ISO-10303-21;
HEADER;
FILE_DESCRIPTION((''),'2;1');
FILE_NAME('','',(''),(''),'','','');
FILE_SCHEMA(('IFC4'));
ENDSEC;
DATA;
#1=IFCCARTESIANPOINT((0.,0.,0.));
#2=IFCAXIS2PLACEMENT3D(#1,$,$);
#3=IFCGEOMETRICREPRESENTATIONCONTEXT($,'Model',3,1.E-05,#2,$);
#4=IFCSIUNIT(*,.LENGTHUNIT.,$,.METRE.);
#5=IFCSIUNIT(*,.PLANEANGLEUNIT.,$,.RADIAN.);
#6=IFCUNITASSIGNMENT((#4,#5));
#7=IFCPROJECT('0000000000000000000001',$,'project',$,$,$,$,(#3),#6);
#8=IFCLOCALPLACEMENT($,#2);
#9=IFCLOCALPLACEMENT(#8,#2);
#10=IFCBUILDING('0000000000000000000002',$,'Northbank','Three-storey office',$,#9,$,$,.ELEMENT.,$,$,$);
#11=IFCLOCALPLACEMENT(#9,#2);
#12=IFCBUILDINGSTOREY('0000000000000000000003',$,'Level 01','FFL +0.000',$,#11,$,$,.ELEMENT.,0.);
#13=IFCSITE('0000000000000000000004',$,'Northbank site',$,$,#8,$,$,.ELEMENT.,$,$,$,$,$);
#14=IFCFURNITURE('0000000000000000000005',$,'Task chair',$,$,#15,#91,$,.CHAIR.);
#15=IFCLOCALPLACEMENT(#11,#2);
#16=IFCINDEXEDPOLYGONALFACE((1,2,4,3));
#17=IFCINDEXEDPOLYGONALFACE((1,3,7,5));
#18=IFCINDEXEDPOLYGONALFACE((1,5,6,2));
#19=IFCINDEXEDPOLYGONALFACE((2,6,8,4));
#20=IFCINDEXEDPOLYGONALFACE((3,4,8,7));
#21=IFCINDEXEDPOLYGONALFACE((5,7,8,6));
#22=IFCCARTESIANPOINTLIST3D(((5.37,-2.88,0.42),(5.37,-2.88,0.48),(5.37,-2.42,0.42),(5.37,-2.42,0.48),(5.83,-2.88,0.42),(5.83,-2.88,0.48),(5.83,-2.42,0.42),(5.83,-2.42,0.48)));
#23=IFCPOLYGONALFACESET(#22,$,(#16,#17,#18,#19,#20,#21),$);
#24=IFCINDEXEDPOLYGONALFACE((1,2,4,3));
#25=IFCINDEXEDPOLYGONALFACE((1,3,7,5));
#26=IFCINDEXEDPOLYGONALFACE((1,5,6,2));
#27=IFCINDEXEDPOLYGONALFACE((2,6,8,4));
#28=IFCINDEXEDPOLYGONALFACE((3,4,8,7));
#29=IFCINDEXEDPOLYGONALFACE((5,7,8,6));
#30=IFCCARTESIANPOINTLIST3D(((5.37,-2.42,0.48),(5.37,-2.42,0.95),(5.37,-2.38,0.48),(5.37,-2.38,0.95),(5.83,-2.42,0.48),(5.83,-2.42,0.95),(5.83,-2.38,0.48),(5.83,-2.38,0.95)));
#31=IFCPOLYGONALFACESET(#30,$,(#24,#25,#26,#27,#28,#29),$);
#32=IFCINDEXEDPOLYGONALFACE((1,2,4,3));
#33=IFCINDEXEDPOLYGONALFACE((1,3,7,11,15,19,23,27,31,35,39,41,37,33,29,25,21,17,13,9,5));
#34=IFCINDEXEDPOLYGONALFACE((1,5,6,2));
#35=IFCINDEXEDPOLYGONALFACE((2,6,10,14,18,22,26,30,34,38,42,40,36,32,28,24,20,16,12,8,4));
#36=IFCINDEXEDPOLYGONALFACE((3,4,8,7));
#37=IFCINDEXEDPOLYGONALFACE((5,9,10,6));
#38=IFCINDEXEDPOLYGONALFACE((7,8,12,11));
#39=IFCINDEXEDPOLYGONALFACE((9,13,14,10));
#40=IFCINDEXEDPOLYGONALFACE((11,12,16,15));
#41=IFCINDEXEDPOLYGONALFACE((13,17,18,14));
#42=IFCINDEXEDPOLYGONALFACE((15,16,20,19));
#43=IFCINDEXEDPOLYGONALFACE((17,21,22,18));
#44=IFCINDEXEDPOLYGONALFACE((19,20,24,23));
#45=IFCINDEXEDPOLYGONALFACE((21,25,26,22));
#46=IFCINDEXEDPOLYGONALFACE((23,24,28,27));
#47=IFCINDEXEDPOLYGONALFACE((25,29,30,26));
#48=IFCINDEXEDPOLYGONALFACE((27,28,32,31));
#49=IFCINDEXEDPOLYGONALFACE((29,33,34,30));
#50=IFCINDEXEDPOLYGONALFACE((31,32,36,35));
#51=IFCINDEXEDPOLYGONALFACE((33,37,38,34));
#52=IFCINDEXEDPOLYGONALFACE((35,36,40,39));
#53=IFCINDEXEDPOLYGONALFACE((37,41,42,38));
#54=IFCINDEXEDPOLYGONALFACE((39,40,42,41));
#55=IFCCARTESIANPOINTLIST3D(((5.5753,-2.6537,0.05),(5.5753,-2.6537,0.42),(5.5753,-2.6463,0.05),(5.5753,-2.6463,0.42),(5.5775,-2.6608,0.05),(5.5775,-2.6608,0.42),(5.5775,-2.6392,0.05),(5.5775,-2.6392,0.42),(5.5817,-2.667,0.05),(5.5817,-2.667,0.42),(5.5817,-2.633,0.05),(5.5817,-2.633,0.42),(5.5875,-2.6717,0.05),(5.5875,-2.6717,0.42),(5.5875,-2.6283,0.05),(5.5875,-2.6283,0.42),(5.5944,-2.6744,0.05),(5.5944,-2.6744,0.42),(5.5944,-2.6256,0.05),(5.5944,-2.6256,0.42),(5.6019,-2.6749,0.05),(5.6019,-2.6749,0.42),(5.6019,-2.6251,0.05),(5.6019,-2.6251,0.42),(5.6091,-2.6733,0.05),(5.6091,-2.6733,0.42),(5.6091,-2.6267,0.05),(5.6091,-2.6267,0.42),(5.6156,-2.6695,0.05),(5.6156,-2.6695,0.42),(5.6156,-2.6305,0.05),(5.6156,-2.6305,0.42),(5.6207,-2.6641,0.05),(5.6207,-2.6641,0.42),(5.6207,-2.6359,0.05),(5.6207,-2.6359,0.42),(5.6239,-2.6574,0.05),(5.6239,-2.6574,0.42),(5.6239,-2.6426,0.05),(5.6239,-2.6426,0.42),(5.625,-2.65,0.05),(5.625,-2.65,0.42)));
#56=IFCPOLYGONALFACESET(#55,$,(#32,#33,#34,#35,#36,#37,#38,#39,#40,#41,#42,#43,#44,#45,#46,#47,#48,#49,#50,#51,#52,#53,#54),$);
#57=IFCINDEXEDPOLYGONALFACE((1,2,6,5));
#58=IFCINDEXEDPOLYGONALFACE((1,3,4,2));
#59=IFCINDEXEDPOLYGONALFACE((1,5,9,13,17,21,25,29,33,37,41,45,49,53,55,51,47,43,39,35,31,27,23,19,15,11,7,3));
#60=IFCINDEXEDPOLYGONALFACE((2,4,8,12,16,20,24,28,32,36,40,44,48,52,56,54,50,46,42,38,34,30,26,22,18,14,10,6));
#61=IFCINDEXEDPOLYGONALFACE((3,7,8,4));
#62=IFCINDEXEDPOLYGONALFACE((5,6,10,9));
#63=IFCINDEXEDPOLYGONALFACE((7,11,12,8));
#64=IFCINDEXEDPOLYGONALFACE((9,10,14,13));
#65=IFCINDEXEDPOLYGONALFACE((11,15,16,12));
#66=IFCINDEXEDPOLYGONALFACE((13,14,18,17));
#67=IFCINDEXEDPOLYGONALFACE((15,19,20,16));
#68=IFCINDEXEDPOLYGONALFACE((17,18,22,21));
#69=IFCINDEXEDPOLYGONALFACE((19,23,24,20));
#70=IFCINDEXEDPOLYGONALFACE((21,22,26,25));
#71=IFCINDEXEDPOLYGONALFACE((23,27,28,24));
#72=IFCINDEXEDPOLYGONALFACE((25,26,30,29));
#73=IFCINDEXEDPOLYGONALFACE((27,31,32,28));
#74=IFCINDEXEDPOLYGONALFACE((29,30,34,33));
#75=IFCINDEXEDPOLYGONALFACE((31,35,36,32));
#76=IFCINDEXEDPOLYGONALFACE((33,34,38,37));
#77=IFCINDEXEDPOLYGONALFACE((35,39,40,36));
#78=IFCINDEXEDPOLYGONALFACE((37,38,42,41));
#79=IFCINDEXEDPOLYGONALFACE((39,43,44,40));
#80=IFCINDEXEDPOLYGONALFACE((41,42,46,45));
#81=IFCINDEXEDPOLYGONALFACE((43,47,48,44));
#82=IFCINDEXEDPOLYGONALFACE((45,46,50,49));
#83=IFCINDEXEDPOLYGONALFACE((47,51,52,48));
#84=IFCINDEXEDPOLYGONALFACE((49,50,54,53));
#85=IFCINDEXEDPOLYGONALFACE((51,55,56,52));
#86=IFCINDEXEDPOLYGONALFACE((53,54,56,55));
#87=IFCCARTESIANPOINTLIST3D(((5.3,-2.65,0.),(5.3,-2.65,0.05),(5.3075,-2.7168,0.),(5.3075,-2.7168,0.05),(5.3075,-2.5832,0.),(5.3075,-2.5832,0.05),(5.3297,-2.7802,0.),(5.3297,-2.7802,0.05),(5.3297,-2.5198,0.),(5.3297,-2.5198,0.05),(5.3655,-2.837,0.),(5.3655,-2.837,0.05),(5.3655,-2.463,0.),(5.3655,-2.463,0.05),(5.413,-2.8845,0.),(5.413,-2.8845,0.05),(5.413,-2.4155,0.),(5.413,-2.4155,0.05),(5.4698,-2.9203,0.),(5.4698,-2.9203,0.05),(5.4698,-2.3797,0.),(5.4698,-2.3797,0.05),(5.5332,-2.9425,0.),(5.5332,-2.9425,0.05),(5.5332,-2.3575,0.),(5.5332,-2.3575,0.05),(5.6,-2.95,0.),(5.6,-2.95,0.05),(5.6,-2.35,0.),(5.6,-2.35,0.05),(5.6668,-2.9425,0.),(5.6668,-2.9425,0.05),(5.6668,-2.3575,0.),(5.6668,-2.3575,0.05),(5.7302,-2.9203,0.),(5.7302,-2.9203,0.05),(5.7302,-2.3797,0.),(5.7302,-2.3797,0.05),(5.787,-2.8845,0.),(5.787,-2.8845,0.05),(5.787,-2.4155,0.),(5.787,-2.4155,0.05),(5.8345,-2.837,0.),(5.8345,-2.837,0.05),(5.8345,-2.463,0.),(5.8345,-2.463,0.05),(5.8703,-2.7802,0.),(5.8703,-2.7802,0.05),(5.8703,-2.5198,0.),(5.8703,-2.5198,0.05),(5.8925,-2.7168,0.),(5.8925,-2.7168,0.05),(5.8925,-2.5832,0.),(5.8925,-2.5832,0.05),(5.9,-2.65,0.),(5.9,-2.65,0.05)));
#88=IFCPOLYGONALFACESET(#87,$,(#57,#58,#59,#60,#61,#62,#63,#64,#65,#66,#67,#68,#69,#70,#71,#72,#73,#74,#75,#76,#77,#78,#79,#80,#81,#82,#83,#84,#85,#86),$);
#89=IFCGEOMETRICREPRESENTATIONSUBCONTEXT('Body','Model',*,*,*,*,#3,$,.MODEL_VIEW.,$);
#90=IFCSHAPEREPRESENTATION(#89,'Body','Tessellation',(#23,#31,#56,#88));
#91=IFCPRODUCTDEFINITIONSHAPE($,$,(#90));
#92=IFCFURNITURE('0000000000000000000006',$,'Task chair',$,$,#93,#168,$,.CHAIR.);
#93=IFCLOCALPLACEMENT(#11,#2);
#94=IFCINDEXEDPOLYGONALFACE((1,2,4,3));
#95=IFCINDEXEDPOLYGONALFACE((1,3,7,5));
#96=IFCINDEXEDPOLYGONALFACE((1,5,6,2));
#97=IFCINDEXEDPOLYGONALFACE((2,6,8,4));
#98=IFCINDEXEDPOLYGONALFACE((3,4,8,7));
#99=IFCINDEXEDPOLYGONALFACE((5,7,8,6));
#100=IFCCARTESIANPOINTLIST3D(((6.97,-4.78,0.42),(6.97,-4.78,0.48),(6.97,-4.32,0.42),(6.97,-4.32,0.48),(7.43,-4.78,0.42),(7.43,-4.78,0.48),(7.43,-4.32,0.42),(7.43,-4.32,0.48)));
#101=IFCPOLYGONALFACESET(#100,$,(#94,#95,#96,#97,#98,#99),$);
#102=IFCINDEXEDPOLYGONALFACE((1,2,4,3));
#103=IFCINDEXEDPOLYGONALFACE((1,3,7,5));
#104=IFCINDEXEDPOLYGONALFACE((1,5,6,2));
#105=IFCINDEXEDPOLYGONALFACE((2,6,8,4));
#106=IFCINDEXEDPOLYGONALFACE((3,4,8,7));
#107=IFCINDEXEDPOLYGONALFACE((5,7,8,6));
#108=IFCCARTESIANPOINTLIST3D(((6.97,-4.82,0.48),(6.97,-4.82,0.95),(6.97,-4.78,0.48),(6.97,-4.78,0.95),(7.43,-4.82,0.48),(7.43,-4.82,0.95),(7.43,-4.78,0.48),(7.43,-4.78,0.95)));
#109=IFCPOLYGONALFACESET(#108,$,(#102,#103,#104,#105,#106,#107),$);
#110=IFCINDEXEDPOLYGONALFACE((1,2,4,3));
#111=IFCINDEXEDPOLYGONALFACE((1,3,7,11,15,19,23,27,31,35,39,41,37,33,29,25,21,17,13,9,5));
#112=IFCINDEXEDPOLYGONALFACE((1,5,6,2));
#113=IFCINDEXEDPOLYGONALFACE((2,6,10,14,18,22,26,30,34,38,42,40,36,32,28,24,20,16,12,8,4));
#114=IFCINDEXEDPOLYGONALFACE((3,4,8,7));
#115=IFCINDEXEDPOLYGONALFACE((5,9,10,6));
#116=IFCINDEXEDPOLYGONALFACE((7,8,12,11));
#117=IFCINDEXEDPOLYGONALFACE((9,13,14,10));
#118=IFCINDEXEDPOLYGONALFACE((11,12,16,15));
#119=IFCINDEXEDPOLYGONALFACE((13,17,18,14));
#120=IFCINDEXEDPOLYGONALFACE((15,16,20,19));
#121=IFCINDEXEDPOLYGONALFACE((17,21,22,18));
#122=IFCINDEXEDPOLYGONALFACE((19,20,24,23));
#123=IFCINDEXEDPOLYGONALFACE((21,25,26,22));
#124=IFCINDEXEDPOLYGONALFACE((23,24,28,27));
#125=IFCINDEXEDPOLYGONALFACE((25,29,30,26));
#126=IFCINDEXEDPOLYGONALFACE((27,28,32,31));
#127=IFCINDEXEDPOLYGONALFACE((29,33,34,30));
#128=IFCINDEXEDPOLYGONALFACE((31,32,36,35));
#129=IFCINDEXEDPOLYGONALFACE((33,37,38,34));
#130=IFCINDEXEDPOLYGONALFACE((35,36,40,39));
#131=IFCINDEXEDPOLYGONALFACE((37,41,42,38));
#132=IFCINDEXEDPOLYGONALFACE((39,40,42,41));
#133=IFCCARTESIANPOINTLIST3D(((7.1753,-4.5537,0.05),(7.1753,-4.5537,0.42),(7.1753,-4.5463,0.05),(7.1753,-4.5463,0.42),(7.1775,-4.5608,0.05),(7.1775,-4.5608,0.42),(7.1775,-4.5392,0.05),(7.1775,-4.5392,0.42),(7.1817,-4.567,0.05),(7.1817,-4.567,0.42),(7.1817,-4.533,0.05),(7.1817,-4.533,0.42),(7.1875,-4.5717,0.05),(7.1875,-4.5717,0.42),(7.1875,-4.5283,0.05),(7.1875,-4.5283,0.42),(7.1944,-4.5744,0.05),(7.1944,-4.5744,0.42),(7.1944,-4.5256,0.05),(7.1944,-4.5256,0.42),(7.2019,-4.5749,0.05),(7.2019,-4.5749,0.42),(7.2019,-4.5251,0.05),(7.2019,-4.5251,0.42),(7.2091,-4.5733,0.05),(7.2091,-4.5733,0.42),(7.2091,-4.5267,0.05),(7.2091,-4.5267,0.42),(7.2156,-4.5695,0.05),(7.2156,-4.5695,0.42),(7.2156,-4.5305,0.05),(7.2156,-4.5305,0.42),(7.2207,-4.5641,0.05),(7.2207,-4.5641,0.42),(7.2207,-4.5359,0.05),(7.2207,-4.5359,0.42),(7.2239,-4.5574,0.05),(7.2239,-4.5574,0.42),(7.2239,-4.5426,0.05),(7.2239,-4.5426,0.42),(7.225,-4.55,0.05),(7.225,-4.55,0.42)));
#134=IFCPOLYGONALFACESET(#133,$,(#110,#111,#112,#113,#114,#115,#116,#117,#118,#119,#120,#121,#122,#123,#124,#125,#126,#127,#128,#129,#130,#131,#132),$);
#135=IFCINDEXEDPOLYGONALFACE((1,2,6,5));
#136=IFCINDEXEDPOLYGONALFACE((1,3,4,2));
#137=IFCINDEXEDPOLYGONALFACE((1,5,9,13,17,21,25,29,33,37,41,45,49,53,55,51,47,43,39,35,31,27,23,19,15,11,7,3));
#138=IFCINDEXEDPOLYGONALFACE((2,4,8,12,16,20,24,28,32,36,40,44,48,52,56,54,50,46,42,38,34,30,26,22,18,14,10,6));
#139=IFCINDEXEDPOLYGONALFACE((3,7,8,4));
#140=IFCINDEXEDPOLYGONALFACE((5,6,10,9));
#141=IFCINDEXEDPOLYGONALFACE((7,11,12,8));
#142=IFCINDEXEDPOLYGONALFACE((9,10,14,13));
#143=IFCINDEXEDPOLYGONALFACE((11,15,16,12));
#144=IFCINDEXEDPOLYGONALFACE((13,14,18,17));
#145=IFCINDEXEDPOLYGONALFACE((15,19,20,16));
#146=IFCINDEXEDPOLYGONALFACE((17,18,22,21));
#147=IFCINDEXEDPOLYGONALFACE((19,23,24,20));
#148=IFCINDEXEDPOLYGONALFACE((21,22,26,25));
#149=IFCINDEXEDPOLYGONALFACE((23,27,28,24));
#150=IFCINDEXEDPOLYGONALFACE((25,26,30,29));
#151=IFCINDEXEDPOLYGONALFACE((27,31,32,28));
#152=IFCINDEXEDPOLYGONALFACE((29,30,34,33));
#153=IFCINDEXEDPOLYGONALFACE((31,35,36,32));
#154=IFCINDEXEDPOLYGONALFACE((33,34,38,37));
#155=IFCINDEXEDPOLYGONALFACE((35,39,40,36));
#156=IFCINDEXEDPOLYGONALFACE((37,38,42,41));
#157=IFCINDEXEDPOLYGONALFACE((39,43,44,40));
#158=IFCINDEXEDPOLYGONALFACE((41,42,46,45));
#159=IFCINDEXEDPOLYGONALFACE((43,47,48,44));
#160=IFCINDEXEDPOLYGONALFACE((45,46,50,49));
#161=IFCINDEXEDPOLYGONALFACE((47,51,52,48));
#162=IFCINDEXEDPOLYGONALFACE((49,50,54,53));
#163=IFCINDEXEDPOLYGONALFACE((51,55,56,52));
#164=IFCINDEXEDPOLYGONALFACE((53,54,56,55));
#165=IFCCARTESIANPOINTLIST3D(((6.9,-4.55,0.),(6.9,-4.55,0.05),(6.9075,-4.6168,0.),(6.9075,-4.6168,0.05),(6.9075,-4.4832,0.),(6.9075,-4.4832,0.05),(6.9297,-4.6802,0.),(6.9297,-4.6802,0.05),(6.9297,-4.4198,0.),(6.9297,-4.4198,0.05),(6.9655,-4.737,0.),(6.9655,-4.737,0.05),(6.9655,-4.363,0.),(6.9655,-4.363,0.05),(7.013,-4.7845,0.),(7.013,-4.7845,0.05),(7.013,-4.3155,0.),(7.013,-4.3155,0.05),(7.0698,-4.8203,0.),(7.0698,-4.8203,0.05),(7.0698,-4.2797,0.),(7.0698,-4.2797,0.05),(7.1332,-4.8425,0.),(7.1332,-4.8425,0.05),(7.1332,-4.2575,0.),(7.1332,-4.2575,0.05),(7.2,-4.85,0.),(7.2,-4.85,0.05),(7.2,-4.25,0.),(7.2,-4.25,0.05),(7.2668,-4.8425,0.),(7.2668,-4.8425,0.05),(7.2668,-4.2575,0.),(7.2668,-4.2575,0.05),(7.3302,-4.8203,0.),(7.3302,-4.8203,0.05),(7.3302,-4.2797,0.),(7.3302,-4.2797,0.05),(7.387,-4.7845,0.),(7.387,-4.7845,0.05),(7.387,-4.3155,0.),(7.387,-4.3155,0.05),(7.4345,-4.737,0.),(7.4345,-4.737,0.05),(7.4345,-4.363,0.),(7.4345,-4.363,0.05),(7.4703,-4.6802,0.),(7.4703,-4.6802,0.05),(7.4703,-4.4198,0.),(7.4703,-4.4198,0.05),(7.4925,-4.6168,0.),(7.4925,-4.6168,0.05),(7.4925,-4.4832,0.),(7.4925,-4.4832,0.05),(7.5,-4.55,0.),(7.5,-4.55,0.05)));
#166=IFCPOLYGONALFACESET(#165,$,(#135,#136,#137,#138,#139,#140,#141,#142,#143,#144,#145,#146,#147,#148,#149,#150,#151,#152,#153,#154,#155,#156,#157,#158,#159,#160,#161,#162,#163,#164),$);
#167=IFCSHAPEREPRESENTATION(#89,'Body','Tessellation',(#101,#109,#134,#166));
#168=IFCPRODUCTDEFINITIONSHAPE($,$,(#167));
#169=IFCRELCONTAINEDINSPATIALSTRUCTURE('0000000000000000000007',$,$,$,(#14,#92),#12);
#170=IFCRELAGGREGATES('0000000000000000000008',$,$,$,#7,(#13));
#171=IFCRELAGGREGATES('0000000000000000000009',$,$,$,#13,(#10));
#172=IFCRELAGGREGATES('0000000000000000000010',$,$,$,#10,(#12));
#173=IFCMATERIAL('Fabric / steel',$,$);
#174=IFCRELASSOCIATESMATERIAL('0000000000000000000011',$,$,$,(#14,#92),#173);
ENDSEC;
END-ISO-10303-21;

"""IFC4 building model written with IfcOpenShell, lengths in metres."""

from ifc_helpers import new_model, si_unit, frame, origin, place, context, subcontext, project, spatial, rectangle, circle, extrude, material, element, save


model = new_model("IFC4")

# Units and contexts
model_context = context("Model", 3, precision=1e-05, world=origin())
body_context = subcontext(model_context, "Body", "Model", "MODEL_VIEW")
ifc_project = project(units=[si_unit("LENGTHUNIT", "METRE"), si_unit("PLANEANGLEUNIT", "RADIAN")], contexts=[model_context])

# Site, building, storey
site_placement = place(None, origin())
site = spatial("IfcSite", under=ifc_project, at=site_placement, Name="Northbank site", CompositionType="ELEMENT")
building_placement = place(site_placement, origin())
building = spatial("IfcBuilding", under=site, at=building_placement, Name="Northbank", Description="Three-storey office", CompositionType="ELEMENT")
storey_placement = place(building_placement, origin())
storey = spatial("IfcBuildingStorey", under=building, at=storey_placement, Name="Level 01", Description="FFL +0.000", CompositionType="ELEMENT", Elevation=0.0)

# Furniture
ifc_material_1 = material(Name="Fabric / steel")
furniture_1_placement = place(storey_placement, origin())
element("IfcFurniture", 1, at=furniture_1_placement, inside=storey, material=ifc_material_1, Name="Task chair", PredefinedType="CHAIR", context=body_context, shape_type="SweptSolid", body=[
    extrude(rectangle(XDim=0.46, YDim=0.46), frame((5.6, -2.65, 0.42)), (0.0, 0.0, 1.0), 0.06),
    extrude(rectangle(XDim=0.46, YDim=0.04), frame((5.6, -2.4, 0.48)), (0.0, 0.0, 1.0), 0.47),
    extrude(circle(Radius=0.025), frame((5.6, -2.65, 0.05), z_axis=(0.0, 0.0, 1.0), x_axis=(1.0, 0.0, 0.0)), (0.0, 0.0, 1.0), 0.37),
    extrude(circle(Radius=0.3), frame((5.6, -2.65, 0.0), z_axis=(0.0, 0.0, 1.0), x_axis=(1.0, 0.0, 0.0)), (0.0, 0.0, 1.0), 0.05),
])
furniture_2_placement = place(storey_placement, origin())
element("IfcFurniture", 2, at=furniture_2_placement, inside=storey, material=ifc_material_1, Name="Task chair", PredefinedType="CHAIR", context=body_context, shape_type="SweptSolid", body=[
    extrude(rectangle(XDim=0.46, YDim=0.46), frame((7.2, -4.55, 0.42)), (0.0, 0.0, 1.0), 0.06),
    extrude(rectangle(XDim=0.46, YDim=0.04), frame((7.2, -4.8, 0.48)), (0.0, 0.0, 1.0), 0.47),
    extrude(circle(Radius=0.025), frame((7.2, -4.55, 0.05), z_axis=(0.0, 0.0, 1.0), x_axis=(1.0, 0.0, 0.0)), (0.0, 0.0, 1.0), 0.37),
    extrude(circle(Radius=0.3), frame((7.2, -4.55, 0.0), z_axis=(0.0, 0.0, 1.0), x_axis=(1.0, 0.0, 0.0)), (0.0, 0.0, 1.0), 0.05),
])

save(model, "model.ifc")
